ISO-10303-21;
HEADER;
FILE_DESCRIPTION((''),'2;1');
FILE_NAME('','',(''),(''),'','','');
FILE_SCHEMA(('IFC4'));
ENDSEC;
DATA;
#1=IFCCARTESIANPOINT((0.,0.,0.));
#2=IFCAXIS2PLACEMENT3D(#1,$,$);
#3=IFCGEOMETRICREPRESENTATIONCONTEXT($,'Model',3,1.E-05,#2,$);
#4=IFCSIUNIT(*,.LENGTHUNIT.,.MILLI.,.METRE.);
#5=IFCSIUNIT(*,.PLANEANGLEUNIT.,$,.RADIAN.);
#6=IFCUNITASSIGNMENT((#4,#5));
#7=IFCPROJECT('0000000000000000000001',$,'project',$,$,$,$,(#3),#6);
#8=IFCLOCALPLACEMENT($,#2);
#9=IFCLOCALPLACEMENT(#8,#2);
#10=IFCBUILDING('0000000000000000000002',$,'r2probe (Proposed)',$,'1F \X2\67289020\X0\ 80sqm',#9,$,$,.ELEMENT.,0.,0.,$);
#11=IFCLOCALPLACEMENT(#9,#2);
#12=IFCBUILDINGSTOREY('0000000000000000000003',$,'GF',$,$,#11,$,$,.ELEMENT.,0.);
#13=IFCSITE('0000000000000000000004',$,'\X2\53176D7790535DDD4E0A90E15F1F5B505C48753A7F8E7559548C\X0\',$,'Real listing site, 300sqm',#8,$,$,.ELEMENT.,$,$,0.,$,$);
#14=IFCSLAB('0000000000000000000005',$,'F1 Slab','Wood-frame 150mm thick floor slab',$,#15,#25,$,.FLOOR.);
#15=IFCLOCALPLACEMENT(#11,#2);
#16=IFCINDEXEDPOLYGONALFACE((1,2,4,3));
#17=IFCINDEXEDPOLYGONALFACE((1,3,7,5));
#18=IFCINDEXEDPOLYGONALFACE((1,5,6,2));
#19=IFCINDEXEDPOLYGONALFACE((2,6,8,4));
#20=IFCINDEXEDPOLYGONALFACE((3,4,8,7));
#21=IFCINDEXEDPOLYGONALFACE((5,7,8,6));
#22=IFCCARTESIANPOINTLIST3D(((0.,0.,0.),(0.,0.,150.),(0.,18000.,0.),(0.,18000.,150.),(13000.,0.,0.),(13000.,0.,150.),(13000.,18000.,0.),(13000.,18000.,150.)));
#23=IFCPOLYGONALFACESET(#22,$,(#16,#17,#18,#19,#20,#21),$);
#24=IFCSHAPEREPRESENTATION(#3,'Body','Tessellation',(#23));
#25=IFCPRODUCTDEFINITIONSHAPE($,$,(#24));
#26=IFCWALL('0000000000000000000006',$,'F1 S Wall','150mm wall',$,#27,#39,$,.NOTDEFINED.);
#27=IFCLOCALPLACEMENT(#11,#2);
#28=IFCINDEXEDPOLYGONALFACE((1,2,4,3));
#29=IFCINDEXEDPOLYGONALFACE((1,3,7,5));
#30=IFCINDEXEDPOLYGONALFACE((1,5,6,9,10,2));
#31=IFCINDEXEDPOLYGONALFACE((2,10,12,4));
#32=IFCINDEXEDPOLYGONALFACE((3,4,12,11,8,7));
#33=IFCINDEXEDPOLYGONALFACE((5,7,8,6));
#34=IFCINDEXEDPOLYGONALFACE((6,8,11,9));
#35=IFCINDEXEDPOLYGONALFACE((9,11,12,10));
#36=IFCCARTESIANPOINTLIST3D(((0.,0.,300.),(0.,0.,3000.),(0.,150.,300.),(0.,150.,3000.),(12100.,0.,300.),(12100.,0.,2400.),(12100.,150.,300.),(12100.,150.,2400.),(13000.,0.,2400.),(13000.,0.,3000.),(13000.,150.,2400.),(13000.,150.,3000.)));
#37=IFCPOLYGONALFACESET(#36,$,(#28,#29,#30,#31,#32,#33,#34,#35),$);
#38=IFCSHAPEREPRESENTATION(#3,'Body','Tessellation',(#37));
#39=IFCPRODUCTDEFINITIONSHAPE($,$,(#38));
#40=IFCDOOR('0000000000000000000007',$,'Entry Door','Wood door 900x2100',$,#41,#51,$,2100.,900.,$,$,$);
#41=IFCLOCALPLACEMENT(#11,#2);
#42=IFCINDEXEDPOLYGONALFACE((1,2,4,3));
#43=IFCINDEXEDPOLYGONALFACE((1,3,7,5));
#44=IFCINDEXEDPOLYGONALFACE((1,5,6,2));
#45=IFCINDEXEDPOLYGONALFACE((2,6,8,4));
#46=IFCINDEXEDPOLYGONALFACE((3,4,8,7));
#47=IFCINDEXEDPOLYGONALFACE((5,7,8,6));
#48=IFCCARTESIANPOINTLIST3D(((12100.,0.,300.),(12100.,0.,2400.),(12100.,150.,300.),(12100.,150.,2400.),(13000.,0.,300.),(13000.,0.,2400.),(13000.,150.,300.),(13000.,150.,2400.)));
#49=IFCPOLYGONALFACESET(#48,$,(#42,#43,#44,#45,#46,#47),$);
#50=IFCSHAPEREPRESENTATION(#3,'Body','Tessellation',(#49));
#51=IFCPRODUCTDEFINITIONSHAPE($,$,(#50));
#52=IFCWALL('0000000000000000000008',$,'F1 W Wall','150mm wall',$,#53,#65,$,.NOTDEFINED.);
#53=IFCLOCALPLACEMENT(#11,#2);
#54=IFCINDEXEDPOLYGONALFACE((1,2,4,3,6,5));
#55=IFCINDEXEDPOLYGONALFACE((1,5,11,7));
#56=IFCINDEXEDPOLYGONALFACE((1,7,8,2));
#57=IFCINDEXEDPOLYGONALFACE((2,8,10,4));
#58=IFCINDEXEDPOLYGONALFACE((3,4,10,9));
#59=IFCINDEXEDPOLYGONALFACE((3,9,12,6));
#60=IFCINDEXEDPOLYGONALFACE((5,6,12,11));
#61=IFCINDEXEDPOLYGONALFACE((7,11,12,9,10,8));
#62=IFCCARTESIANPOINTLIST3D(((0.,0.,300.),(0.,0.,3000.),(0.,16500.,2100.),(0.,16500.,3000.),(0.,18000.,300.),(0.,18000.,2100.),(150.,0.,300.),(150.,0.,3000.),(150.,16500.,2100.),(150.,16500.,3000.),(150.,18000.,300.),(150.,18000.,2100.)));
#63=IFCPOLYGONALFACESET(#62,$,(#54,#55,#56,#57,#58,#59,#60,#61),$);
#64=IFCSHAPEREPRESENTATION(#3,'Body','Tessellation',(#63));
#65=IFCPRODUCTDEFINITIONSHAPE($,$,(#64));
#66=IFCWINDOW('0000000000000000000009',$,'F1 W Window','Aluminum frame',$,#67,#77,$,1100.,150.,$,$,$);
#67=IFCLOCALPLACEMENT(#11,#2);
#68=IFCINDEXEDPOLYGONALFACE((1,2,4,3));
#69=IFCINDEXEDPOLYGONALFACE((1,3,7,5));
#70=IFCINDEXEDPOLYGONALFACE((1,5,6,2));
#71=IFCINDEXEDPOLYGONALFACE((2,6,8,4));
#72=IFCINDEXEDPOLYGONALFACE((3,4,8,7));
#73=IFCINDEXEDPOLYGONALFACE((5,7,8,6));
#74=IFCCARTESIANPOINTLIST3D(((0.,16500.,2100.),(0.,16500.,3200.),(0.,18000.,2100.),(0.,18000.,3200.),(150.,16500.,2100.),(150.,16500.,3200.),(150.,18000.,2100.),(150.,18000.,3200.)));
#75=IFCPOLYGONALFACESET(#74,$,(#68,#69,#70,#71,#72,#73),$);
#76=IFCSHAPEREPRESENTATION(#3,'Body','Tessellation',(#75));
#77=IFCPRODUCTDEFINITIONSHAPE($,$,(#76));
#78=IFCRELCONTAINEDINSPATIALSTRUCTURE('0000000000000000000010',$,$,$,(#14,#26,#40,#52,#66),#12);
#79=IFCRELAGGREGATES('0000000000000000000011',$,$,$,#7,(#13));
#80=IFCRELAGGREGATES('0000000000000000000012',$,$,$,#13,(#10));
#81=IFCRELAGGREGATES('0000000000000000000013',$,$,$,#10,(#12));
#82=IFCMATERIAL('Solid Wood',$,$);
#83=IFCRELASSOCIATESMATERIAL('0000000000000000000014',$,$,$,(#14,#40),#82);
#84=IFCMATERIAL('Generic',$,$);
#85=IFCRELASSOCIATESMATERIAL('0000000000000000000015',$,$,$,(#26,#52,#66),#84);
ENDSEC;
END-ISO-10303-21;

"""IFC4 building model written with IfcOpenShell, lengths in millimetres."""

from ifc_helpers import new_model, si_unit, frame, frame_2d, origin, place, context, project, spatial, rectangle, extrude, material, element, fill, save


model = new_model("IFC4")

# Units and contexts
model_context = context("Model", 3, precision=1e-05, world=origin())
ifc_project = project(units=[si_unit("LENGTHUNIT", "METRE", prefix="MILLI"), si_unit("PLANEANGLEUNIT", "RADIAN")], contexts=[model_context])

# Site, building, storey
site_placement = place(None, origin())
site = spatial("IfcSite", under=ifc_project, at=site_placement, Name="北海道川上郡弟子屈町美留和", ObjectType="Real listing site, 300sqm", CompositionType="ELEMENT", RefElevation=0.0)
building_placement = place(site_placement, origin())
building = spatial("IfcBuilding", under=site, at=building_placement, Name="r2probe (Proposed)", ObjectType="1F 木造 80sqm", CompositionType="ELEMENT", ElevationOfRefHeight=0.0, ElevationOfTerrain=0.0)
storey_placement = place(building_placement, origin())
storey = spatial("IfcBuildingStorey", under=building, at=storey_placement, Name="GF", CompositionType="ELEMENT", Elevation=0.0)

# Slab
ifc_material_1 = material(Name="Solid Wood")
slab_placement = place(storey_placement, origin())
element("IfcSlab", 1, at=slab_placement, inside=storey, material=ifc_material_1, Name="F1 Slab", Description="Wood-frame 150mm thick floor slab", PredefinedType="FLOOR", context=model_context, shape_type="SweptSolid", body=[
    extrude(rectangle(XDim=13000.0, YDim=18000.0, at=frame_2d((6500.0, 9000.0))), origin(), (0.0, 0.0, 1.0), 150.0),
])

# Shared definitions
ifc_material_2 = material(Name="Generic")

# Wall, opening, door
wall_1_placement = place(storey_placement, frame((0.0, 0.0, 150.0)))
wall_1 = element("IfcWall", 2, at=wall_1_placement, inside=storey, material=ifc_material_2, Name="F1 S Wall", Description="150mm wall", PredefinedType="NOTDEFINED", context=model_context, shape_type="SweptSolid", body=[
    extrude(rectangle(XDim=13000.0, YDim=150.0, at=frame_2d((6500.0, 75.0))), frame((0.0, 0.0, 150.0)), (0.0, 0.0, 1.0), 2700.0),
])
opening_1_placement = place(storey_placement, frame((6050.0, 0.0, 150.0)))
opening_1 = element("IfcOpeningElement", 3, at=opening_1_placement, cuts=wall_1, PredefinedType="NOTDEFINED", context=model_context, shape_type="SweptSolid", body=[
    extrude(rectangle(XDim=900.0, YDim=150.0, at=frame_2d((450.0, 75.0))), frame((6050.0, 0.0, 150.0)), (0.0, 0.0, 1.0), 2100.0),
])
door_placement = place(storey_placement, frame((6050.0, 0.0, 150.0)))
door = element("IfcDoor", 4, at=door_placement, inside=storey, material=ifc_material_1, Name="Entry Door", Description="Wood door 900x2100", OverallHeight=2100.0, OverallWidth=900.0, context=model_context, shape_type="SweptSolid", body=[
    extrude(rectangle(XDim=900.0, YDim=150.0, at=frame_2d((450.0, 75.0))), frame((6050.0, 0.0, 150.0)), (0.0, 0.0, 1.0), 2100.0),
])
fill(opening_1, door)

# Wall, opening, window
wall_2_placement = place(storey_placement, frame((0.0, 0.0, 150.0)))
wall_2 = element("IfcWall", 5, at=wall_2_placement, inside=storey, material=ifc_material_2, Name="F1 W Wall", Description="150mm wall", PredefinedType="NOTDEFINED", context=model_context, shape_type="SweptSolid", body=[
    extrude(rectangle(XDim=150.0, YDim=18000.0, at=frame_2d((75.0, 9000.0))), frame((0.0, 0.0, 150.0)), (0.0, 0.0, 1.0), 2700.0),
])
opening_2_placement = place(storey_placement, frame((0.0, 8250.0, 1050.0)))
opening_2 = element("IfcOpeningElement", 6, at=opening_2_placement, cuts=wall_2, PredefinedType="NOTDEFINED", context=model_context, shape_type="SweptSolid", body=[
    extrude(rectangle(XDim=150.0, YDim=1500.0, at=frame_2d((75.0, 750.0))), frame((0.0, 8250.0, 1050.0)), (0.0, 0.0, 1.0), 1100.0),
])
window_1_placement = place(storey_placement, frame((0.0, 8250.0, 1050.0)))
window_1 = element("IfcWindow", 7, at=window_1_placement, inside=storey, material=ifc_material_2, Name="F1 W Window", Description="Aluminum frame", OverallHeight=1100.0, OverallWidth=150.0, context=model_context, shape_type="SweptSolid", body=[
    extrude(rectangle(XDim=150.0, YDim=1500.0, at=frame_2d((75.0, 750.0))), frame((0.0, 8250.0, 1050.0)), (0.0, 0.0, 1.0), 1100.0),
])
fill(opening_2, window_1)

save(model, "model.ifc")
